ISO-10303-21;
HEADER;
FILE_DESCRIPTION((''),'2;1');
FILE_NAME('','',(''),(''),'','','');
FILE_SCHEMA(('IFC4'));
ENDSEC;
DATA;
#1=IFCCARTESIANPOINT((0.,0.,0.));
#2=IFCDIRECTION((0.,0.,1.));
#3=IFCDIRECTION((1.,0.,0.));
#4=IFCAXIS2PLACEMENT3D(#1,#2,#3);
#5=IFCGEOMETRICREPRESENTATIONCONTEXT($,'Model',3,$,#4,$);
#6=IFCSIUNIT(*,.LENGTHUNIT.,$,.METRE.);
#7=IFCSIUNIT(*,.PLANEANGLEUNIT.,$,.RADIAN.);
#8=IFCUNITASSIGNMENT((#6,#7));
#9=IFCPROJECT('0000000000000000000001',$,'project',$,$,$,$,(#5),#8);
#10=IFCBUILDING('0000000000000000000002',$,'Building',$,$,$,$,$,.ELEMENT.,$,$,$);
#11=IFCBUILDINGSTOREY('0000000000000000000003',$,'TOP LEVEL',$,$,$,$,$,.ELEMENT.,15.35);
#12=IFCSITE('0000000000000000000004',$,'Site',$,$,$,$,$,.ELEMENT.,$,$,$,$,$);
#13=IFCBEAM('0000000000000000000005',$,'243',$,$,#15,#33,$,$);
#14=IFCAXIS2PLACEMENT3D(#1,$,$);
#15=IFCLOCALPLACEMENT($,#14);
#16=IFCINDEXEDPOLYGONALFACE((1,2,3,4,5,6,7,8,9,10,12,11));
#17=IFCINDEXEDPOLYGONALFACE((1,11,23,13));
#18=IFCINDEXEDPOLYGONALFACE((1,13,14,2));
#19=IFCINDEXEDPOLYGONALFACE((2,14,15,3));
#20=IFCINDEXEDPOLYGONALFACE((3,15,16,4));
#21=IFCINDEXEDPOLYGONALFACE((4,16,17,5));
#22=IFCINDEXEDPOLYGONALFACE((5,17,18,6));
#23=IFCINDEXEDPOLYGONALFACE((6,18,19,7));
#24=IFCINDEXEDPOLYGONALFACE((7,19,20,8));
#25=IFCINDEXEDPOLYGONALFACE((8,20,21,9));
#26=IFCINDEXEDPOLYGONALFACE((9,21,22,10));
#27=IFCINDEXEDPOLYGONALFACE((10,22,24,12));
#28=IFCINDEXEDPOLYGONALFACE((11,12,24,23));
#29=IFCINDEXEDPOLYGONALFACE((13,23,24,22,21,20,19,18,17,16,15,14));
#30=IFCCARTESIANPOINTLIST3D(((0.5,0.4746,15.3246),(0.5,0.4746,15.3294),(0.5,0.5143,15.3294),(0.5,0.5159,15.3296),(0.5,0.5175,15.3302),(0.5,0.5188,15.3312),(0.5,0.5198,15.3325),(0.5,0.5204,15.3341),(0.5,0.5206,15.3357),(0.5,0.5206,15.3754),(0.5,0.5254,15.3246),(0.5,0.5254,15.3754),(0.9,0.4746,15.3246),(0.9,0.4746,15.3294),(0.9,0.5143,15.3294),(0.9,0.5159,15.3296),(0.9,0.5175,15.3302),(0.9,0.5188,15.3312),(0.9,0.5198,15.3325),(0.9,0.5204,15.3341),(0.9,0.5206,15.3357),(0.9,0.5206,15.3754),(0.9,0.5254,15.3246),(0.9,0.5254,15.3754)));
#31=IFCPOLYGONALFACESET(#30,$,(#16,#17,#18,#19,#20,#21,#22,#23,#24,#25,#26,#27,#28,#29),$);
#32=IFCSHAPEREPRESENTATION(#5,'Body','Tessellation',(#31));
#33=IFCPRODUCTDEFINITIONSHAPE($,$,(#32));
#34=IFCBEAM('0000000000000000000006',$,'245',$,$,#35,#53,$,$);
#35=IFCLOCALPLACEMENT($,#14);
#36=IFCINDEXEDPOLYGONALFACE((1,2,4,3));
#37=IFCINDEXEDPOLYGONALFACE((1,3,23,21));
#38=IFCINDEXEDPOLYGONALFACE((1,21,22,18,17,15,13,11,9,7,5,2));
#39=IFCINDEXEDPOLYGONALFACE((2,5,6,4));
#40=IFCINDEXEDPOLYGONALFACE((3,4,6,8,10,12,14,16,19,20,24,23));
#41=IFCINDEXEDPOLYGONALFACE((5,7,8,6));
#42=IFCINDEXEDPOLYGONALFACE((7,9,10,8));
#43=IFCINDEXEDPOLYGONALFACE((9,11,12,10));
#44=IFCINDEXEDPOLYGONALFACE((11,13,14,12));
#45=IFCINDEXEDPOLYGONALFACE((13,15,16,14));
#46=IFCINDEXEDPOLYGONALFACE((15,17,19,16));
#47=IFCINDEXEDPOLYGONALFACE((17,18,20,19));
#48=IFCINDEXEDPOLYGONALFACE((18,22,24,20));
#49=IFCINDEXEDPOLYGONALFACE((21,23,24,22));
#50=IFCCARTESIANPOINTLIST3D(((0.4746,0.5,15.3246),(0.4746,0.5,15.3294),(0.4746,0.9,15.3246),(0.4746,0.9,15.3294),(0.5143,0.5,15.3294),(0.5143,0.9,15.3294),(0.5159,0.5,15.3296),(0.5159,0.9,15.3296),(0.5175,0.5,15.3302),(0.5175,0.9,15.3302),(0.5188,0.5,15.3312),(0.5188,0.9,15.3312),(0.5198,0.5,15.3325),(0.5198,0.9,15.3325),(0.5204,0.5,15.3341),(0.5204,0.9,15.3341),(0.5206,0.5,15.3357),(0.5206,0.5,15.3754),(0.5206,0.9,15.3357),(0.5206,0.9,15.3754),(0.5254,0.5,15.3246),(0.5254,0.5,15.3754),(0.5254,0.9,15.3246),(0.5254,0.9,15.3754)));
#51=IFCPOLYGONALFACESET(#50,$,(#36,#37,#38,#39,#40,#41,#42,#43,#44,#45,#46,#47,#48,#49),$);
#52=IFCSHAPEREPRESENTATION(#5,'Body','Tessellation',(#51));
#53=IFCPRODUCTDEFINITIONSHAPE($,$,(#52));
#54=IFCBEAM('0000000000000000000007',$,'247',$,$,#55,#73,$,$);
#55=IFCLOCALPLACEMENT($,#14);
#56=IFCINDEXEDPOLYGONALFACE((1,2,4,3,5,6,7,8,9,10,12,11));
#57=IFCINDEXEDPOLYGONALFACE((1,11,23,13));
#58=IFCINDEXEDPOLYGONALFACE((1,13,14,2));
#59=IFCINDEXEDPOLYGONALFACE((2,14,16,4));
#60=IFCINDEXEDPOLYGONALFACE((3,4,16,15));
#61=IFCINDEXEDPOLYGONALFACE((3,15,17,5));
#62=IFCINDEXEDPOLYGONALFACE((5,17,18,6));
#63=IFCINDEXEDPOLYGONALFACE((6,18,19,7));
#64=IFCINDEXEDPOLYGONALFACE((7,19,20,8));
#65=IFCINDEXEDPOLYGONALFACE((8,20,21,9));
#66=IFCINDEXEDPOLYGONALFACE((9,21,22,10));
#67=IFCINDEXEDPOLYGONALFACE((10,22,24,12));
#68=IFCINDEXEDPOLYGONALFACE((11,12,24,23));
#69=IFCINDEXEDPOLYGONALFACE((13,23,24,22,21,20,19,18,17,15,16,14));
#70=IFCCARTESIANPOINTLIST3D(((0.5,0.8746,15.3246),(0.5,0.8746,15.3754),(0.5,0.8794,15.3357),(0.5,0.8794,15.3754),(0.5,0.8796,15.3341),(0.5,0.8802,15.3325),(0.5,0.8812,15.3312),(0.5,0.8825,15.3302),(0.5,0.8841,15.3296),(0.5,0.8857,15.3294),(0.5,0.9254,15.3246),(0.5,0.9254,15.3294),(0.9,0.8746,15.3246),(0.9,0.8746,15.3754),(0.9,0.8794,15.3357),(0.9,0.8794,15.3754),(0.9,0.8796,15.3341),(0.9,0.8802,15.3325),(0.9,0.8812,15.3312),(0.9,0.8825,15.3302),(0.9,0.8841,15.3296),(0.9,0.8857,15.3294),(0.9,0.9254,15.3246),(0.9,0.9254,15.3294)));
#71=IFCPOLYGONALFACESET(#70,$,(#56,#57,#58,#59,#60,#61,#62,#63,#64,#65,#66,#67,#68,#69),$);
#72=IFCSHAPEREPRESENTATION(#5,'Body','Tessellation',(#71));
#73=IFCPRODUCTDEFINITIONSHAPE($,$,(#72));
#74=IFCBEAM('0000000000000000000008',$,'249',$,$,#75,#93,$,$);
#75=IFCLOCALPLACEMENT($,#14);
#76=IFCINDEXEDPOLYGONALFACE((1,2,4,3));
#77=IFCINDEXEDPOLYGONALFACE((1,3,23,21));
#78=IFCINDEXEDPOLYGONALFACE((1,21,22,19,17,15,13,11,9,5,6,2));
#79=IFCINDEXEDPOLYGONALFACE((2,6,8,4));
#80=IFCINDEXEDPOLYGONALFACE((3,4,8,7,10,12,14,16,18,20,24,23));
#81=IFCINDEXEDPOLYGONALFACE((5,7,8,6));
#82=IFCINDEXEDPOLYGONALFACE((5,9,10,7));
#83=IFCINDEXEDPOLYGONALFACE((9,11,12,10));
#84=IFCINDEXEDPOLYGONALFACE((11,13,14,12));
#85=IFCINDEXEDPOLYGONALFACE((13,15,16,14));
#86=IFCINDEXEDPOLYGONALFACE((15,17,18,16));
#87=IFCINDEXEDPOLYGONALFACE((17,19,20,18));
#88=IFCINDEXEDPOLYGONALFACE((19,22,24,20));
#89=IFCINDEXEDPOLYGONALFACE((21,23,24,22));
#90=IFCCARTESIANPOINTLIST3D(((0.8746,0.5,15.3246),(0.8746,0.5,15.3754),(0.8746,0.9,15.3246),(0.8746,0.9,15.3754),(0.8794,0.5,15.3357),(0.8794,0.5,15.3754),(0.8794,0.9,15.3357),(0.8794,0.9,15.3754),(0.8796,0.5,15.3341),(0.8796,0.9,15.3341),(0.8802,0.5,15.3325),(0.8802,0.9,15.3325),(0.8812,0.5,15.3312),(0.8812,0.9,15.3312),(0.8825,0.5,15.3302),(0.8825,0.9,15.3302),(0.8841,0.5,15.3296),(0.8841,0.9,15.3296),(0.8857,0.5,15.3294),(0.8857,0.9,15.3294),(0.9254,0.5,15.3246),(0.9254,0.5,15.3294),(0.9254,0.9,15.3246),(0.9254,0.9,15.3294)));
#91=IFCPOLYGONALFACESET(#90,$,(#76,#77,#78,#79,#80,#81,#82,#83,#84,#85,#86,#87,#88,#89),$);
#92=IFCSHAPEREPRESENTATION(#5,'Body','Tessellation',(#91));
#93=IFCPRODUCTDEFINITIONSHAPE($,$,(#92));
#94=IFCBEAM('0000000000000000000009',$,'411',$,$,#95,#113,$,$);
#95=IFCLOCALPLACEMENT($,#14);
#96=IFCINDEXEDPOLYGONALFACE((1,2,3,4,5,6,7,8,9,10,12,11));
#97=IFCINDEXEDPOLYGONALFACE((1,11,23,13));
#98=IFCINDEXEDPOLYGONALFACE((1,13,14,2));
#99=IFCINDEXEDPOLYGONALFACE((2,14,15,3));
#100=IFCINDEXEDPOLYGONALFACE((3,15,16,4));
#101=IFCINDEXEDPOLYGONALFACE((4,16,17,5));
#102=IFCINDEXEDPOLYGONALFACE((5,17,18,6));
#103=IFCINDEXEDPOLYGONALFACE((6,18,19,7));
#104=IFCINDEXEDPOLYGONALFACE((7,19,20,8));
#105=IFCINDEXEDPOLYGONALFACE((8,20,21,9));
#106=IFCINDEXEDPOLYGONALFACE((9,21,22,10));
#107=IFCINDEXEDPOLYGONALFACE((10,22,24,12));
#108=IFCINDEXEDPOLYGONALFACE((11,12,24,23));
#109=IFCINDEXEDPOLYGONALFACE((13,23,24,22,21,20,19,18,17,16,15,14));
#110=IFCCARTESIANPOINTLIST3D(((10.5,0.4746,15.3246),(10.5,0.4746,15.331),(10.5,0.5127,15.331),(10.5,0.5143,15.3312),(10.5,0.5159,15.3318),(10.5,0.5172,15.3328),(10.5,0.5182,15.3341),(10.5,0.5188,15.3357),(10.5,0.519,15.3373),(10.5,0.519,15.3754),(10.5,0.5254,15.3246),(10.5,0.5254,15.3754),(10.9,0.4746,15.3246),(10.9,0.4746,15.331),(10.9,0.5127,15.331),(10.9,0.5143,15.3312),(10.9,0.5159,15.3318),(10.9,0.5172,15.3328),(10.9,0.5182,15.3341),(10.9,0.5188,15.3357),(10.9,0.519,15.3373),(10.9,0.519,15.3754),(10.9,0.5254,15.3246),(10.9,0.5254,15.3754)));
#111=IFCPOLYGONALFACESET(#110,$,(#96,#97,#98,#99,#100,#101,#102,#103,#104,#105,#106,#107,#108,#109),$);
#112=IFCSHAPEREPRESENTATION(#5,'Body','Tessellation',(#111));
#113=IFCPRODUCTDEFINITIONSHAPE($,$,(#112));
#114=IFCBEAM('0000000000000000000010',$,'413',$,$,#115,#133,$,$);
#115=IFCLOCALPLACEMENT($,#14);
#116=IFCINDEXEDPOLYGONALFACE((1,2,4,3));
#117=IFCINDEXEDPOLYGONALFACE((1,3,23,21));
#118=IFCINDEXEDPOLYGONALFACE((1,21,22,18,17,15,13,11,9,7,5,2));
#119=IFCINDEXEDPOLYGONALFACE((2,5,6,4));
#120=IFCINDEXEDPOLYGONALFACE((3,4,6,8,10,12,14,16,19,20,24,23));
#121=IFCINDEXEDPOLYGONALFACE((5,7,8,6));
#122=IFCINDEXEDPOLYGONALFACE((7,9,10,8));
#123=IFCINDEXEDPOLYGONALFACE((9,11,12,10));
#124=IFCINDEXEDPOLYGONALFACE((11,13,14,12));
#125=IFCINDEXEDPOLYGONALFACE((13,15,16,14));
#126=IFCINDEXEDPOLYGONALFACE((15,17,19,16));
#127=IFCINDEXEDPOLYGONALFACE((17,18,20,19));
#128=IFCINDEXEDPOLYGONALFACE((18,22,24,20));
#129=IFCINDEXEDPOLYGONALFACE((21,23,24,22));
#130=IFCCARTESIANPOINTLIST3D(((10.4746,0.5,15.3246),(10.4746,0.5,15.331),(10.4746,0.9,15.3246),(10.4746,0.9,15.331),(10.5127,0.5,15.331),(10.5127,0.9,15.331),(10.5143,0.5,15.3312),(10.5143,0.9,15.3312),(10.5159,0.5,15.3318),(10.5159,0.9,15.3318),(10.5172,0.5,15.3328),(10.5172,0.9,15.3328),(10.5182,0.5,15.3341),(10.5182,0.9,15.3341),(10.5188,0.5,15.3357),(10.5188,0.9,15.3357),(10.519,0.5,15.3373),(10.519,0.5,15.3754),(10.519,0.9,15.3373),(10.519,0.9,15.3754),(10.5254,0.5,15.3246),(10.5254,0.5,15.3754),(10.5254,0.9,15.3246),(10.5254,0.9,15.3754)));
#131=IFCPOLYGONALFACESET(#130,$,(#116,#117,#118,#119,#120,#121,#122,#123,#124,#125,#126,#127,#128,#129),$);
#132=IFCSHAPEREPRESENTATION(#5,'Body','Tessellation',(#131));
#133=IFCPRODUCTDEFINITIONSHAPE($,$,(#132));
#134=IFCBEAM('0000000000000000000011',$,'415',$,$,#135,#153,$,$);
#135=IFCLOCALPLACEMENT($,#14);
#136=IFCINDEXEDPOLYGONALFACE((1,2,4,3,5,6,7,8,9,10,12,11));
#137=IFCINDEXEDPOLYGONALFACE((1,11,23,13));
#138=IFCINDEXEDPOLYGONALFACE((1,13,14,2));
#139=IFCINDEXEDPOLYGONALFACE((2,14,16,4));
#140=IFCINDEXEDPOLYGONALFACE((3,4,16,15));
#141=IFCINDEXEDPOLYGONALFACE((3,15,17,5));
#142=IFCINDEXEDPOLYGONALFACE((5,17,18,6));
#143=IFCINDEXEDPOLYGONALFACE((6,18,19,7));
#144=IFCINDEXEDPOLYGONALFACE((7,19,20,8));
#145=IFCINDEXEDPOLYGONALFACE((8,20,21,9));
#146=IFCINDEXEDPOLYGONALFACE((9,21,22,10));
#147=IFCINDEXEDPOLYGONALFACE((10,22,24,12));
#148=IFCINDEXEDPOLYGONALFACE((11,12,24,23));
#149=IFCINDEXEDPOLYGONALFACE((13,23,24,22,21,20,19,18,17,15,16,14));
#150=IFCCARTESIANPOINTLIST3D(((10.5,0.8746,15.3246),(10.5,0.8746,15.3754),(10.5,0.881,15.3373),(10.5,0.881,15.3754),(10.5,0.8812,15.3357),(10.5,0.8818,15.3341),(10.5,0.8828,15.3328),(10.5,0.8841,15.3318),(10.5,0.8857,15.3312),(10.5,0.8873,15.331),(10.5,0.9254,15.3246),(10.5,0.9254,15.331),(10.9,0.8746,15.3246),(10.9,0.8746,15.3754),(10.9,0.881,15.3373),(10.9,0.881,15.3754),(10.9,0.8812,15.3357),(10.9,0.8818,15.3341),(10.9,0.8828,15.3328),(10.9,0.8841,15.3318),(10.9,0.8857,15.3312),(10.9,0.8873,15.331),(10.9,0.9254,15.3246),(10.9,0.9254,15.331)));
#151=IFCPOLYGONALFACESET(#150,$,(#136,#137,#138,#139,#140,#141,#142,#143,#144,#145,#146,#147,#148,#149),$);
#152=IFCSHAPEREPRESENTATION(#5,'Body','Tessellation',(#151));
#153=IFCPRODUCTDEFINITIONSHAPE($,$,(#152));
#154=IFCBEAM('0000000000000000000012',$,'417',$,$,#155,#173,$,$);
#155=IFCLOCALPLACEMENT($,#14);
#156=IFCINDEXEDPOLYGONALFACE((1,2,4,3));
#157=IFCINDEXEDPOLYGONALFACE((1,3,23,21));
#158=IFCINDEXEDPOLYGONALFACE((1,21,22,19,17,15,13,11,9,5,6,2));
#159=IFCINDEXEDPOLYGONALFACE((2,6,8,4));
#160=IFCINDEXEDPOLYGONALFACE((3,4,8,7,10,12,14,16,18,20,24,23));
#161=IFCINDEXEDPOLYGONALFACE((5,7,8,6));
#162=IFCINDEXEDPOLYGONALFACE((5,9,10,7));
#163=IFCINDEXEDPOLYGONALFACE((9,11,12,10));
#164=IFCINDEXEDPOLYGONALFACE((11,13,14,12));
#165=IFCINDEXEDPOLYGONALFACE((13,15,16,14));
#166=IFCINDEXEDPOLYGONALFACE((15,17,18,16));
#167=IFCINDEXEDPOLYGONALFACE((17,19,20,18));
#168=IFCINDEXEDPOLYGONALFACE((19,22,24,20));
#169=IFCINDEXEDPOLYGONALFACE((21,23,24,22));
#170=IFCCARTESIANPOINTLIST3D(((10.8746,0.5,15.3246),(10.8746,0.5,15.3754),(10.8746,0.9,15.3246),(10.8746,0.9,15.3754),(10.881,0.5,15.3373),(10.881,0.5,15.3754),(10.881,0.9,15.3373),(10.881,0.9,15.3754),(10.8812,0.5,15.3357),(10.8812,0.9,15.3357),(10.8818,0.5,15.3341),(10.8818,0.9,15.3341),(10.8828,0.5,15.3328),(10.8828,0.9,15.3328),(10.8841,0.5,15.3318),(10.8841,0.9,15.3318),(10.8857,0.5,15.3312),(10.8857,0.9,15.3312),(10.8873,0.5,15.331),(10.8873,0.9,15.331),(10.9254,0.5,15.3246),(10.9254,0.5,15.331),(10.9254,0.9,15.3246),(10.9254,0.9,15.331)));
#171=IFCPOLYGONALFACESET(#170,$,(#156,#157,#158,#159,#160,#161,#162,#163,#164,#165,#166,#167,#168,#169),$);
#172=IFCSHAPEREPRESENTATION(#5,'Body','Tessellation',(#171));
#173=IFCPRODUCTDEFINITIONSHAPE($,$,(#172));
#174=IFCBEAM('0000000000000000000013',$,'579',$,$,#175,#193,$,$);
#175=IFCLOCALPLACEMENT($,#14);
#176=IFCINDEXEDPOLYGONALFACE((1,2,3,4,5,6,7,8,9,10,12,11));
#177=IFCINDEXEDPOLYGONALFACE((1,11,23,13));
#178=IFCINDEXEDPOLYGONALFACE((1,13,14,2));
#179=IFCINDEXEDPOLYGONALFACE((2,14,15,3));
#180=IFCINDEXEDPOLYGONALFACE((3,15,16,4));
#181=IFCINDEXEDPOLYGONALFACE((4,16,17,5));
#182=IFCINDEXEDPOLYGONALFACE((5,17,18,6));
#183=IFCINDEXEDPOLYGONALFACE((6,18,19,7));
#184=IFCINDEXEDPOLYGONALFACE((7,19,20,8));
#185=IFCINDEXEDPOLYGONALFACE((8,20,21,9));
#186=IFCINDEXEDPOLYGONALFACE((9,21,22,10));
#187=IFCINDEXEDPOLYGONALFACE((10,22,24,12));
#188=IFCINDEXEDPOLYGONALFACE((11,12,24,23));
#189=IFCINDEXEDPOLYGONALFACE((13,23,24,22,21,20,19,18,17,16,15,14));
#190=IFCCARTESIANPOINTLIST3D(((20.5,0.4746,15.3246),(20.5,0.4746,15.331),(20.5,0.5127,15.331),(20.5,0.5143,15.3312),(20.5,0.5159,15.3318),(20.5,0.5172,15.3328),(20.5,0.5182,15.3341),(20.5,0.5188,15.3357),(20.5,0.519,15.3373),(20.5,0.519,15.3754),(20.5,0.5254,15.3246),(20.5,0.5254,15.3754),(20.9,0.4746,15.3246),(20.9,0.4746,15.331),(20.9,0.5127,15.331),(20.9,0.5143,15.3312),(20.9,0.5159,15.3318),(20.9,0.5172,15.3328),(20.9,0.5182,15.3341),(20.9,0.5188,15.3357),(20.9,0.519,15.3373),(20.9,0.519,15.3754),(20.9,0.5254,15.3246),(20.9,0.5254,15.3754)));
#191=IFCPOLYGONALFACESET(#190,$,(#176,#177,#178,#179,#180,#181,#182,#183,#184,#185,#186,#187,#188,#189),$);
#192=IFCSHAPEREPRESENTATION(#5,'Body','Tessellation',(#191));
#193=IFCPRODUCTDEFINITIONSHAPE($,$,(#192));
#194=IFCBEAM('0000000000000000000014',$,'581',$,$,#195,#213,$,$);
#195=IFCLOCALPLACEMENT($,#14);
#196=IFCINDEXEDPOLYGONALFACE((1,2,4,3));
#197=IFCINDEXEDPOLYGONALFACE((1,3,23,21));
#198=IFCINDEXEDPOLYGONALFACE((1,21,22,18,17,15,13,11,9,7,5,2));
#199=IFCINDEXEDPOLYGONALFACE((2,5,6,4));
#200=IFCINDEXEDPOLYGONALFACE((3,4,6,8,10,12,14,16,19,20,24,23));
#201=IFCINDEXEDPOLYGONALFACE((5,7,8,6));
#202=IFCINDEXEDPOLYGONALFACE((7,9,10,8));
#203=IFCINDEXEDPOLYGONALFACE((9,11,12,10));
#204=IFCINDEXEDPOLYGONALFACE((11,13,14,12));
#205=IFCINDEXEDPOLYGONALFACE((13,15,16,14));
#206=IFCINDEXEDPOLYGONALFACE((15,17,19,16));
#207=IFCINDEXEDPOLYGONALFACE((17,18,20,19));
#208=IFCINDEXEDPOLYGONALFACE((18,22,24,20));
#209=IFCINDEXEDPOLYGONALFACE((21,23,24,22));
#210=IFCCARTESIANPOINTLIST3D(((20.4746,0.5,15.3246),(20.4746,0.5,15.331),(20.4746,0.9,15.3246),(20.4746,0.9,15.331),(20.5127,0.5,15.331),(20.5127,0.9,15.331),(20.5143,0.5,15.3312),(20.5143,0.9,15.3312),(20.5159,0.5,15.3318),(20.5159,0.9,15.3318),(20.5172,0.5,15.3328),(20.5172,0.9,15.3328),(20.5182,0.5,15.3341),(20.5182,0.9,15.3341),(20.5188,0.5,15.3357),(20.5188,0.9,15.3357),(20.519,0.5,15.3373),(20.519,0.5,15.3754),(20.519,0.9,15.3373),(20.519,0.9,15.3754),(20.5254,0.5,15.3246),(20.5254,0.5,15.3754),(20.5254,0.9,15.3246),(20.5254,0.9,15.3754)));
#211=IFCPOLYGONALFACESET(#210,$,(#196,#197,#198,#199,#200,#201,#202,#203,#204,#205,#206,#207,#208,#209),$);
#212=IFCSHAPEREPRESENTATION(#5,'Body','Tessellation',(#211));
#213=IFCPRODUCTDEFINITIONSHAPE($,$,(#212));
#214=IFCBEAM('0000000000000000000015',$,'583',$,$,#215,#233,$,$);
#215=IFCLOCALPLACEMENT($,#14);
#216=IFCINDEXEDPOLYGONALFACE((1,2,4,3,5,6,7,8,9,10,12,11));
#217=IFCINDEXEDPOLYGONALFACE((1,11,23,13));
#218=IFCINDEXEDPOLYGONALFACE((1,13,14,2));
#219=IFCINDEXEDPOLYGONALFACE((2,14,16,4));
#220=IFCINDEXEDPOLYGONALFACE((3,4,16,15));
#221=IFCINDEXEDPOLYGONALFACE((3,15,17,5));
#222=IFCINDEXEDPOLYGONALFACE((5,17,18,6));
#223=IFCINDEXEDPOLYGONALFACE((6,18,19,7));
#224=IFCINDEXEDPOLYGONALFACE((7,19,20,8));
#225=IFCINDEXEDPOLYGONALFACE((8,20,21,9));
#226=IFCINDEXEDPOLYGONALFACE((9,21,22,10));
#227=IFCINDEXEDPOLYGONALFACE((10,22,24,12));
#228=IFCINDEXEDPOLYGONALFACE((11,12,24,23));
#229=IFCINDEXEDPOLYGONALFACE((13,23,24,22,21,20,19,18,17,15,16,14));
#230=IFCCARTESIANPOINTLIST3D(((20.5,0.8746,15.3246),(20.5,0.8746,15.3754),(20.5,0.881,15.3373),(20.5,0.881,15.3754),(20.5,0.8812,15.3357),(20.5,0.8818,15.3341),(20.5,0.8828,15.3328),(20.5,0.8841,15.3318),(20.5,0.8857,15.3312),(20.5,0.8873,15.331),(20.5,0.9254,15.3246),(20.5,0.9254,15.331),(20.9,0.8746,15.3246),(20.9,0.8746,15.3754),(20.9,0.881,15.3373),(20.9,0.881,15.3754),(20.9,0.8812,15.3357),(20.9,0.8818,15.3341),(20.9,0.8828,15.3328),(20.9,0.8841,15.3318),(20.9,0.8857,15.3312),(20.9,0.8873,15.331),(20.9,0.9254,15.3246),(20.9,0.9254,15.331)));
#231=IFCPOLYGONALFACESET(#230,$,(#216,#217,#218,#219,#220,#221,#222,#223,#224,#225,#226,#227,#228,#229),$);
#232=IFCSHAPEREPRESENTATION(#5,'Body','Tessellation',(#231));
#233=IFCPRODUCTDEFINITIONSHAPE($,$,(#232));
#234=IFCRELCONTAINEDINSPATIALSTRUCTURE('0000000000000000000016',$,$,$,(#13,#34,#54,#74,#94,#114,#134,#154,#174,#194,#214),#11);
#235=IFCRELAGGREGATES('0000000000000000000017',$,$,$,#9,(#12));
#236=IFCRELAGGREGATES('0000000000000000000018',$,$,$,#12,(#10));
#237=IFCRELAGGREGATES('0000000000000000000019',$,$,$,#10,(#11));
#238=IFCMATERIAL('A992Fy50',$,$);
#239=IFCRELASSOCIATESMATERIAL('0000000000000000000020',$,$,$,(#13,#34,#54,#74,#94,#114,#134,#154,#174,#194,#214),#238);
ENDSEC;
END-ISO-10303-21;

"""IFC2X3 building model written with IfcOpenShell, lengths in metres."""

from ifc_helpers import new_model, si_unit, frame, origin_with_axes, origin_2d_with_axis, place, context, project, spatial, l_section, extrude, material, element, save


model = new_model("IFC2X3")

# Units and contexts
model_context = context("Model", 3, world=origin_with_axes())
ifc_project = project(units=[si_unit("LENGTHUNIT", "METRE"), si_unit("PLANEANGLEUNIT", "RADIAN")], contexts=[model_context])

# Site, building, storey
site = spatial("IfcSite", under=ifc_project, Name="Site", CompositionType="ELEMENT")
building = spatial("IfcBuilding", under=site, Name="Building", CompositionType="ELEMENT")
storey = spatial("IfcBuildingStorey", under=building, Name="TOP LEVEL", CompositionType="ELEMENT", Elevation=15.35)

# Beams
ifc_material = material(Name="A992Fy50")
for number, where, z_axis, x_axis, name in (
    (1, (0.9, 0.5, 15.35), (-1.0, 0.0, 0.0), (0.0, -1.0, 0.0), "243"),
    (2, (0.5, 0.5, 15.35), (0.0, 1.0, 0.0), (-1.0, 0.0, 0.0), "245"),
    (3, (0.5, 0.9, 15.35), (1.0, 0.0, 0.0), (0.0, 1.0, 0.0), "247"),
    (4, (0.9, 0.9, 15.35), (0.0, -1.0, 0.0), (1.0, 0.0, 0.0), "249"),
):
    element("IfcBeam", number, at=place(None, frame(where, z_axis=z_axis, x_axis=x_axis)), inside=storey, material=ifc_material, Name=name, context=model_context, shape_type="SweptSolid", body=[
        extrude(l_section(Depth=0.0508, Width=0.0508, Thickness=0.0048, FilletRadius=0.0063, at=origin_2d_with_axis()), origin_with_axes(), (0.0, 0.0, 1.0), 0.4),
    ])
for number, where, z_axis, x_axis, name in (
    (5, (10.9, 0.5, 15.35), (-1.0, 0.0, 0.0), (0.0, -1.0, 0.0), "411"),
    (6, (10.5, 0.5, 15.35), (0.0, 1.0, 0.0), (-1.0, 0.0, 0.0), "413"),
    (7, (10.5, 0.9, 15.35), (1.0, 0.0, 0.0), (0.0, 1.0, 0.0), "415"),
    (8, (10.9, 0.9, 15.35), (0.0, -1.0, 0.0), (1.0, 0.0, 0.0), "417"),
    (9, (20.9, 0.5, 15.35), (-1.0, 0.0, 0.0), (0.0, -1.0, 0.0), "579"),
    (10, (20.5, 0.5, 15.35), (0.0, 1.0, 0.0), (-1.0, 0.0, 0.0), "581"),
    (11, (20.5, 0.9, 15.35), (1.0, 0.0, 0.0), (0.0, 1.0, 0.0), "583"),
):
    element("IfcBeam", number, at=place(None, frame(where, z_axis=z_axis, x_axis=x_axis)), inside=storey, material=ifc_material, Name=name, context=model_context, shape_type="SweptSolid", body=[
        extrude(l_section(Depth=0.0508, Width=0.0508, Thickness=0.0063, FilletRadius=0.0063, at=origin_2d_with_axis()), origin_with_axes(), (0.0, 0.0, 1.0), 0.4),
    ])

save(model, "model.ifc")
